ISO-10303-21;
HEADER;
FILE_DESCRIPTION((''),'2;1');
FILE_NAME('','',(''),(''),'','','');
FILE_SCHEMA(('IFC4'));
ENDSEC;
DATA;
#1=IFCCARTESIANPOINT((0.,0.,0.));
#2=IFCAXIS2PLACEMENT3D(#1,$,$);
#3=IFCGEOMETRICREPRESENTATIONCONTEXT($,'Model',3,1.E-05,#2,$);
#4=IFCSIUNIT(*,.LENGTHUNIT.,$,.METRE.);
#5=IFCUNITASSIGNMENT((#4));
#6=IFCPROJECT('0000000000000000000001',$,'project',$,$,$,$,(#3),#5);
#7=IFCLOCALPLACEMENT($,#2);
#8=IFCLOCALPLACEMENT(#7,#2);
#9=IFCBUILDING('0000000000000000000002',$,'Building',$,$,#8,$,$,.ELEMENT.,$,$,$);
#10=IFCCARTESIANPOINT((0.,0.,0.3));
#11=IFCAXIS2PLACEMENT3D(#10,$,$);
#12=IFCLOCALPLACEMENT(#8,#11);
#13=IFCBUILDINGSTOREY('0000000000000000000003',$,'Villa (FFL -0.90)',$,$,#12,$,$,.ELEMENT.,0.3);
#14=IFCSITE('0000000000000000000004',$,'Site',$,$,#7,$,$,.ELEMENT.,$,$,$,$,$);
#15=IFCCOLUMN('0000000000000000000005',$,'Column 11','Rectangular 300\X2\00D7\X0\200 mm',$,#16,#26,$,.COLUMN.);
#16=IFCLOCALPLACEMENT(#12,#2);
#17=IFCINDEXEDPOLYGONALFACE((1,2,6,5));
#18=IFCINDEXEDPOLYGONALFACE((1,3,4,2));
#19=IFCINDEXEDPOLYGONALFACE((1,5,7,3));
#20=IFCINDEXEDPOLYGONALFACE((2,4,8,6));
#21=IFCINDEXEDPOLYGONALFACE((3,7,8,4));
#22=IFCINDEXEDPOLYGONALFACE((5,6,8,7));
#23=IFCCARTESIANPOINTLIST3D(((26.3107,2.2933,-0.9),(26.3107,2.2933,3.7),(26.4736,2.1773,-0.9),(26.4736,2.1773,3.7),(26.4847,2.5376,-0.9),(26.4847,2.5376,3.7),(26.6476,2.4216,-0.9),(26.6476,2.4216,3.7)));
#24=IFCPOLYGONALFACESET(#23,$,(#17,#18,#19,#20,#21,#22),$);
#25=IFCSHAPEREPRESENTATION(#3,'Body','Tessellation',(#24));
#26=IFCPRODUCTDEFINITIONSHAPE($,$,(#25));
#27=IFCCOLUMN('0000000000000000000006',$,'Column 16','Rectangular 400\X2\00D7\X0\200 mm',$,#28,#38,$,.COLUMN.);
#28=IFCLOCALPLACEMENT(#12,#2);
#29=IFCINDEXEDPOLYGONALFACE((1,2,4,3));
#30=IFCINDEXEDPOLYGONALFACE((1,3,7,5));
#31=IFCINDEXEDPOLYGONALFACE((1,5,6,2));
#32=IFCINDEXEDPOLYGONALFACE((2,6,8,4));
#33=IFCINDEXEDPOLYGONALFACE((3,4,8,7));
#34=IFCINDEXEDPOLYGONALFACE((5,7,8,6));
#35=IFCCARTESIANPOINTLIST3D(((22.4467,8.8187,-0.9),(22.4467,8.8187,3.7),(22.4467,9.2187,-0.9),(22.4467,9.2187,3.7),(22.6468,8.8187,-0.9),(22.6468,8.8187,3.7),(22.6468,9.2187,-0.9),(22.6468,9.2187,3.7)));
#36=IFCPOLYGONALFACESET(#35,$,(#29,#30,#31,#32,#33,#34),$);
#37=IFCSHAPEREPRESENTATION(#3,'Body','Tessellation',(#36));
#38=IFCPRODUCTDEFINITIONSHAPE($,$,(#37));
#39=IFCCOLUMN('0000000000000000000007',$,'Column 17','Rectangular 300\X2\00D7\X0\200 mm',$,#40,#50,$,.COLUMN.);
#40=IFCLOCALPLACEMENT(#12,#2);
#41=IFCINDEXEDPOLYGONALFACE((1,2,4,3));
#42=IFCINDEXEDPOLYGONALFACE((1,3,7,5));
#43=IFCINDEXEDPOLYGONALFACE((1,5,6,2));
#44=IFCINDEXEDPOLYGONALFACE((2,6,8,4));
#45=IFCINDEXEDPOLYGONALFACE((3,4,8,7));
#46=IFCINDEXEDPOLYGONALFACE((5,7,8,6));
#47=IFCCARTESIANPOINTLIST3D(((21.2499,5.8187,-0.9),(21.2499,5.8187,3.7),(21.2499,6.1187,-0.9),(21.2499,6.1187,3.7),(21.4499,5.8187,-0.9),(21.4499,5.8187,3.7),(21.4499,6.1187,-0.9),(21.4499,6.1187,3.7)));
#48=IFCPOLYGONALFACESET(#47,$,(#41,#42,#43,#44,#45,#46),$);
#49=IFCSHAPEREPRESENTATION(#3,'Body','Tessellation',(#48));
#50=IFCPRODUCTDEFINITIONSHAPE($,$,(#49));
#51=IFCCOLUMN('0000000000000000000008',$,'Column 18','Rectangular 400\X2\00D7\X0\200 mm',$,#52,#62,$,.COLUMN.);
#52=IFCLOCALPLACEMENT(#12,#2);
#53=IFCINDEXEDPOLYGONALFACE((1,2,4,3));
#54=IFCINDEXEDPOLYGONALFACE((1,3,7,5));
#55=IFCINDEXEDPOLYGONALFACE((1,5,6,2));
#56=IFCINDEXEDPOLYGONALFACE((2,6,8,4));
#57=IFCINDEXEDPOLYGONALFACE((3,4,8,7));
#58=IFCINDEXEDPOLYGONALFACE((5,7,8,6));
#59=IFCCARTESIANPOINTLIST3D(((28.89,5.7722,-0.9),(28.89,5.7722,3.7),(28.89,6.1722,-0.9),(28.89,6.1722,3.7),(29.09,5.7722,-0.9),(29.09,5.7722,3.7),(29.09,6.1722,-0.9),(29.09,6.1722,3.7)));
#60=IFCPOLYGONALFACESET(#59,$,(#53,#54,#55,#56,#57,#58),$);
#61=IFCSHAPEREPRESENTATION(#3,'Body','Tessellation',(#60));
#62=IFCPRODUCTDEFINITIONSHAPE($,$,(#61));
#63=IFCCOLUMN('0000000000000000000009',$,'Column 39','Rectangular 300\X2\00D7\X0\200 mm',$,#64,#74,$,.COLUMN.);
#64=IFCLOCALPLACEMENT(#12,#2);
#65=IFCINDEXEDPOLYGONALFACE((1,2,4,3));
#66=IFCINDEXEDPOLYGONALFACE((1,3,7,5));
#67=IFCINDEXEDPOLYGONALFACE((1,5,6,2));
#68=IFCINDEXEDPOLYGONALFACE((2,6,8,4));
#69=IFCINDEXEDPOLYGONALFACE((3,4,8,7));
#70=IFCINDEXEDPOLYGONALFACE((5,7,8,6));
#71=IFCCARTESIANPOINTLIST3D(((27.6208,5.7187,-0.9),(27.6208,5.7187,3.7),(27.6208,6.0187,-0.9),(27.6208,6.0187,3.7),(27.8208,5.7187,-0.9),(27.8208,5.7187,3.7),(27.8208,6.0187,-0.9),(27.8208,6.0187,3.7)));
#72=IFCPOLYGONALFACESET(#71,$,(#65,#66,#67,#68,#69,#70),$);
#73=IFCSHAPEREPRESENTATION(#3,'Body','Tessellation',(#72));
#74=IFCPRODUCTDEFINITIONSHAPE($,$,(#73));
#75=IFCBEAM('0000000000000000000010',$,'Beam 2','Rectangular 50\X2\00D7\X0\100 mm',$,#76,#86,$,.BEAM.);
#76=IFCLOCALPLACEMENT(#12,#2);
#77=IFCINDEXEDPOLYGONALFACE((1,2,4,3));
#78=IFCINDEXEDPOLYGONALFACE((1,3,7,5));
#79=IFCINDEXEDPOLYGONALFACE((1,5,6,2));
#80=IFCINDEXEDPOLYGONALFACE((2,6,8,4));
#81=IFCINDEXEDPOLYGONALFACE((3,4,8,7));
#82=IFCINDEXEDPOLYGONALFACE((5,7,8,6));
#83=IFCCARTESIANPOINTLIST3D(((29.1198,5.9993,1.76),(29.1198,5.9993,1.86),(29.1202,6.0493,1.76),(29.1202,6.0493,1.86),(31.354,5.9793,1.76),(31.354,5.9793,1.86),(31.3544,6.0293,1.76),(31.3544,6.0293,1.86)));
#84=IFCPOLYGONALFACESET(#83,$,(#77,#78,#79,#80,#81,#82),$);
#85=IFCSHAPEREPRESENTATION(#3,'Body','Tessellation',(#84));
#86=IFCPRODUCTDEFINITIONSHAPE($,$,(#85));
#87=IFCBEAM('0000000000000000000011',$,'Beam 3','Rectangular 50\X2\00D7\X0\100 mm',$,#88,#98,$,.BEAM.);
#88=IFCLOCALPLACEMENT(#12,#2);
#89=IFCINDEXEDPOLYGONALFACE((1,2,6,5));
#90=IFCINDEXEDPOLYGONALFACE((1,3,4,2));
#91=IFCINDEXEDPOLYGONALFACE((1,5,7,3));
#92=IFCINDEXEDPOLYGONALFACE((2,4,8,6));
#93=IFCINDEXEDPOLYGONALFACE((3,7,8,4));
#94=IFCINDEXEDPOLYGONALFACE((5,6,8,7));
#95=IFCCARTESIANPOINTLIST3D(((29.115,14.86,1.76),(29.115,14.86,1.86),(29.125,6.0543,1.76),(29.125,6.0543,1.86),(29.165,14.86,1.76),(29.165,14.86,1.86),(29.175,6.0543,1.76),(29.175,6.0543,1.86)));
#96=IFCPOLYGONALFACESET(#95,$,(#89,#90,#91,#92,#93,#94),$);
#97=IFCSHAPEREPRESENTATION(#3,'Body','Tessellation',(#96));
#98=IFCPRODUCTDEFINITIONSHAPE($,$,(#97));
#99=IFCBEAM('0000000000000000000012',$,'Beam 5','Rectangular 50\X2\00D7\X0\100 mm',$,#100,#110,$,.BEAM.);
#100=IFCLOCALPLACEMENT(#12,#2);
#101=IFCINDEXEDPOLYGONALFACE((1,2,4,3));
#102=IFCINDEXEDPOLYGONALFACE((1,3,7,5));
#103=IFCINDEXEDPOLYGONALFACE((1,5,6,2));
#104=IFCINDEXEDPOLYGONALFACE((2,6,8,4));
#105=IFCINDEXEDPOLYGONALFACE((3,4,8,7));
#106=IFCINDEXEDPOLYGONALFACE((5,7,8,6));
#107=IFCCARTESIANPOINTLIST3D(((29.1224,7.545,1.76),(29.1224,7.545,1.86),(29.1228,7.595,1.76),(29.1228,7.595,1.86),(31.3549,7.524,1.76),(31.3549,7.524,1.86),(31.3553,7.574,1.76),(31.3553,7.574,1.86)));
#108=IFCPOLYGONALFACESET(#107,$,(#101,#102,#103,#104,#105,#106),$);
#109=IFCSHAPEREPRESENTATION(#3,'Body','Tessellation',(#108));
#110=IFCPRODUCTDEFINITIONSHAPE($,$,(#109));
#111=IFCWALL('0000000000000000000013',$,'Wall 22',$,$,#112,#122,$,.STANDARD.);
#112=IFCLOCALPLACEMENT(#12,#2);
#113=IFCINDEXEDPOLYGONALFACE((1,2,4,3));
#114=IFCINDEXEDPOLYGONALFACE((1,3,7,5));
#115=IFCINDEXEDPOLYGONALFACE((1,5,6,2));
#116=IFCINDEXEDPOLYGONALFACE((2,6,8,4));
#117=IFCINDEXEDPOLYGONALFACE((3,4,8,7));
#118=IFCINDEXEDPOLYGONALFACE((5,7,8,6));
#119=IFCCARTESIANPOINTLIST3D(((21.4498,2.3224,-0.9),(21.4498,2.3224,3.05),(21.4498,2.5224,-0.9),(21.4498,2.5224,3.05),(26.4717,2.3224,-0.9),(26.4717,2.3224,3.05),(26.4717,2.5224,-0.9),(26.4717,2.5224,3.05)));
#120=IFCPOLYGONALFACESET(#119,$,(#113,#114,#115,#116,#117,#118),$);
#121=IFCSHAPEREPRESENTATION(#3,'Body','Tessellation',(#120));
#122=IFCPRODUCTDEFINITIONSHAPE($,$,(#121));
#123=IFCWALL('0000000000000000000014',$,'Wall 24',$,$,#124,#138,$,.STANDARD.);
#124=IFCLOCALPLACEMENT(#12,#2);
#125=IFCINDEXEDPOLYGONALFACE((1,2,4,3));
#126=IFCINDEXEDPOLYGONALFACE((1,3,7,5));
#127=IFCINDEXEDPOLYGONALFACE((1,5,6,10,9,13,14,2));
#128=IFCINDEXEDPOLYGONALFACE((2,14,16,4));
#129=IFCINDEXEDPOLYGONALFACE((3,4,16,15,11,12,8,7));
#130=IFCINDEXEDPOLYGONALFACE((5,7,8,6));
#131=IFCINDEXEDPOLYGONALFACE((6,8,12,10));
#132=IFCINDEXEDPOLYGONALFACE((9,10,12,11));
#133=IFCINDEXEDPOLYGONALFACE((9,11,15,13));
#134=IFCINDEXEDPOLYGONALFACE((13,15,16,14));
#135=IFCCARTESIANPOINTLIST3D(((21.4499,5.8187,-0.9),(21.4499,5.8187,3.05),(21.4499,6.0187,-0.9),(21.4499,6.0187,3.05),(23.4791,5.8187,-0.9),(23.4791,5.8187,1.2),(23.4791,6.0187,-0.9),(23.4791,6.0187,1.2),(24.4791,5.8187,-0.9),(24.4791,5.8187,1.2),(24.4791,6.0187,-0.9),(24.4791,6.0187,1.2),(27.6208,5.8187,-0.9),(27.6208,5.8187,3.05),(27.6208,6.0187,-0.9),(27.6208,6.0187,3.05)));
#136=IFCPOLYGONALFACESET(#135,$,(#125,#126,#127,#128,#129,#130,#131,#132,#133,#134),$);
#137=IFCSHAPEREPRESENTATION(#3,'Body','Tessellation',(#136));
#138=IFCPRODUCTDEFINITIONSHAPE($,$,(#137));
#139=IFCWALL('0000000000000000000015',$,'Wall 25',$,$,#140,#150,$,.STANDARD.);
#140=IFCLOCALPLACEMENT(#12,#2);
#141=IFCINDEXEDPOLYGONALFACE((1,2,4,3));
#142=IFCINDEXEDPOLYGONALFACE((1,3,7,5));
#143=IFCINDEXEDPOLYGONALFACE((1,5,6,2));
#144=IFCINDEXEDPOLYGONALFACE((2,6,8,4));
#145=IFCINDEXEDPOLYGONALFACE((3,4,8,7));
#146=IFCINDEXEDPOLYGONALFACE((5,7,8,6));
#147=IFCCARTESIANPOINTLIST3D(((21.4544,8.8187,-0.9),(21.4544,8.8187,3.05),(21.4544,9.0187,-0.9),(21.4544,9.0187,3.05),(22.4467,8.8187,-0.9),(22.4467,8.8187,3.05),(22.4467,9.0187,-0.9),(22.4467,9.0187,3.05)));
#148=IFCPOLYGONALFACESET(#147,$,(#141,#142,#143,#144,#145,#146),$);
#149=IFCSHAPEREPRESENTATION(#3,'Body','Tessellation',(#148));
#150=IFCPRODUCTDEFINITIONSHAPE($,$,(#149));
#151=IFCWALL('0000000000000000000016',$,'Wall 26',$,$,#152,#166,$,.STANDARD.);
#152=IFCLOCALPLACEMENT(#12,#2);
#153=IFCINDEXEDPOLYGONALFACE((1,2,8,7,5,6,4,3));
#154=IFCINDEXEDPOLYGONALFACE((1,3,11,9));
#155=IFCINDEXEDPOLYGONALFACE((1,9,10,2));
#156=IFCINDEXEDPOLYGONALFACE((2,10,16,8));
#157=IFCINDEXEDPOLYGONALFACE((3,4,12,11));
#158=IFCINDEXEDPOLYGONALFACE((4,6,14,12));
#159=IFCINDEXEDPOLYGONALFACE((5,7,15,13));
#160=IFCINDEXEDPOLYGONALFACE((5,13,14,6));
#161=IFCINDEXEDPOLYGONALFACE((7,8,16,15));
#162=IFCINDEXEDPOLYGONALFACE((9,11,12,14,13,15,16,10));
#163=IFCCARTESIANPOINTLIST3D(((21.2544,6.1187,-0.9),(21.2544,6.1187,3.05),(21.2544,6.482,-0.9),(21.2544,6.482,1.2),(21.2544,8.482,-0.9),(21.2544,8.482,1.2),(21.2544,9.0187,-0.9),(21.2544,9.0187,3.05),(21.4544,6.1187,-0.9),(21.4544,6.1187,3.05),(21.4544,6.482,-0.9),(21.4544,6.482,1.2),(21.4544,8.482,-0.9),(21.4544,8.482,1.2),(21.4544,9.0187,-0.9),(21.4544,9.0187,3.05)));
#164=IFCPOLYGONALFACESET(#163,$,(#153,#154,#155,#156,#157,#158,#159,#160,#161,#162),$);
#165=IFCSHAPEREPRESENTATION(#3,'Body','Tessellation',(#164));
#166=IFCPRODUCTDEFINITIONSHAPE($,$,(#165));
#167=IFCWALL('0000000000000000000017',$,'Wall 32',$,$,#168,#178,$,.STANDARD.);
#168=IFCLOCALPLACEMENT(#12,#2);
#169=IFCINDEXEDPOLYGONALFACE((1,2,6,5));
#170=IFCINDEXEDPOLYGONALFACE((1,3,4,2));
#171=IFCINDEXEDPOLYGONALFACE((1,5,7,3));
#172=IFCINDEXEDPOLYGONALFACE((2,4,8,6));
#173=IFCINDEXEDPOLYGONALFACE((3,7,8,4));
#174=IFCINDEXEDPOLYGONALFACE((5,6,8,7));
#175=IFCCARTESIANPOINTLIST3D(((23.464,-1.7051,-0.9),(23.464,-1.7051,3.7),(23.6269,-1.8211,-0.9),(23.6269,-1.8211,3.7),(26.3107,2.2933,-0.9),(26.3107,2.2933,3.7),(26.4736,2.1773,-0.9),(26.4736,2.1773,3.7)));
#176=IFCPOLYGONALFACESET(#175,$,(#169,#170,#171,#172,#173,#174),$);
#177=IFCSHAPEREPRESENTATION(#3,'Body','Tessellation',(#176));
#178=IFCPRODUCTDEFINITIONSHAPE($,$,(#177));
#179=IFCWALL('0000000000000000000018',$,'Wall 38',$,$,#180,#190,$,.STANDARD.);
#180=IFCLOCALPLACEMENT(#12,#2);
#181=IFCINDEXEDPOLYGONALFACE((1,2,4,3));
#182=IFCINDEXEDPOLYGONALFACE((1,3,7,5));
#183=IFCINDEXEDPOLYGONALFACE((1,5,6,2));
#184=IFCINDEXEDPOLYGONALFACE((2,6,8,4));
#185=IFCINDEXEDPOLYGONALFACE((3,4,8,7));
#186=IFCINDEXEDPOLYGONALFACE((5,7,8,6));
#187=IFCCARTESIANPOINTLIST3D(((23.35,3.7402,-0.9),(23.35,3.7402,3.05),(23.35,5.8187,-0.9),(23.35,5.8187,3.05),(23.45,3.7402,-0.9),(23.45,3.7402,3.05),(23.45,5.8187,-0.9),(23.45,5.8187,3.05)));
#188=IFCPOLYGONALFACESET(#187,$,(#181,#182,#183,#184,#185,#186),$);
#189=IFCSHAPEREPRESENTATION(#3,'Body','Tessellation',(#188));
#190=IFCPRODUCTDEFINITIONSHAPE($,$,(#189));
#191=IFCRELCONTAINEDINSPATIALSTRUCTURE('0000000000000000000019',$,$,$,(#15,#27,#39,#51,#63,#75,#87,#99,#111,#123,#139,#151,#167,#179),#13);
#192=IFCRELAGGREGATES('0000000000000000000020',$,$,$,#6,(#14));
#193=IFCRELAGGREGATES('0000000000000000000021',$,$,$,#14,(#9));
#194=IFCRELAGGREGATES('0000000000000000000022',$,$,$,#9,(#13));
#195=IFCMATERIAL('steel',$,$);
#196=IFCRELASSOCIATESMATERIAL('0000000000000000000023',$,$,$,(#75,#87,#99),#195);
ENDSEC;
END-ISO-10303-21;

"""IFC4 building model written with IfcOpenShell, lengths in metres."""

from ifc_helpers import new_model, si_unit, frame, frame_2d, origin, place, context, project, spatial, polyline, rectangle, outline, extrude, material, element, save


model = new_model("IFC4")

# Units and contexts
model_context = context("Model", 3, precision=1e-05, world=origin())
ifc_project = project(units=[si_unit("LENGTHUNIT", "METRE")], contexts=[model_context])

# Site, building, storey
site_placement = place(None, origin())
site = spatial("IfcSite", under=ifc_project, at=site_placement, Name="Site", CompositionType="ELEMENT")
building_placement = place(site_placement, origin())
building = spatial("IfcBuilding", under=site, at=building_placement, Name="Building", CompositionType="ELEMENT")
storey_placement = place(building_placement, frame((0.0, 0.0, 0.3)))
storey = spatial("IfcBuildingStorey", under=building, at=storey_placement, Name="Villa (FFL -0.90)", CompositionType="ELEMENT", Elevation=0.3)

# Columns
column_1_placement = place(storey_placement, frame((26.4792, 2.3575, -0.9), z_axis=(0.0, 0.0, 1.0), x_axis=(0.579992, 0.814622, 0.0)))
element("IfcColumn", 1, at=column_1_placement, inside=storey, Name="Column 11", Description="Rectangular 300×200 mm", PredefinedType="COLUMN", context=model_context, shape_type="SweptSolid", body=[
    extrude(outline(polyline([(-0.15, -0.1), (0.15, -0.1), (0.15, 0.1), (-0.15, 0.1), (-0.15, -0.1)])), origin(), (0.0, 0.0, 1.0), 4.6),
])
column_2_placement = place(storey_placement, frame((22.5467, 9.0187, -0.9), z_axis=(0.0, 0.0, 1.0), x_axis=(0.0, 1.0, 0.0)))
element("IfcColumn", 2, at=column_2_placement, inside=storey, Name="Column 16", Description="Rectangular 400×200 mm", PredefinedType="COLUMN", context=model_context, shape_type="SweptSolid", body=[
    extrude(outline(polyline([(-0.2, -0.1), (0.2, -0.1), (0.2, 0.1), (-0.2, 0.1), (-0.2, -0.1)])), origin(), (0.0, 0.0, 1.0), 4.6),
])
column_3_placement = place(storey_placement, frame((21.3499, 5.9687, -0.9), z_axis=(0.0, 0.0, 1.0), x_axis=(0.0, 1.0, 0.0)))
element("IfcColumn", 3, at=column_3_placement, inside=storey, Name="Column 17", Description="Rectangular 300×200 mm", PredefinedType="COLUMN", context=model_context, shape_type="SweptSolid", body=[
    extrude(outline(polyline([(-0.15, -0.1), (0.15, -0.1), (0.15, 0.1), (-0.15, 0.1), (-0.15, -0.1)])), origin(), (0.0, 0.0, 1.0), 4.6),
])
column_4_placement = place(storey_placement, frame((28.99, 5.9722, -0.9), z_axis=(0.0, 0.0, 1.0), x_axis=(0.0, 1.0, 0.0)))
element("IfcColumn", 4, at=column_4_placement, inside=storey, Name="Column 18", Description="Rectangular 400×200 mm", PredefinedType="COLUMN", context=model_context, shape_type="SweptSolid", body=[
    extrude(outline(polyline([(-0.2, -0.1), (0.2, -0.1), (0.2, 0.1), (-0.2, 0.1), (-0.2, -0.1)])), origin(), (0.0, 0.0, 1.0), 4.6),
])
column_5_placement = place(storey_placement, frame((27.7208, 5.8687, -0.9), z_axis=(0.0, 0.0, 1.0), x_axis=(0.0, 1.0, 0.0)))
element("IfcColumn", 5, at=column_5_placement, inside=storey, Name="Column 39", Description="Rectangular 300×200 mm", PredefinedType="COLUMN", context=model_context, shape_type="SweptSolid", body=[
    extrude(outline(polyline([(-0.15, -0.1), (0.15, -0.1), (0.15, 0.1), (-0.15, 0.1), (-0.15, -0.1)])), origin(), (0.0, 0.0, 1.0), 4.6),
])

# Beams
ifc_material = material(Name="steel")
beam_1_placement = place(storey_placement, frame((29.12, 6.0243, 1.81), z_axis=(0.99996, -0.008951, 0.0), x_axis=(0.008951, 0.99996, 0.0)))
element("IfcBeam", 6, at=beam_1_placement, inside=storey, material=ifc_material, Name="Beam 2", Description="Rectangular 50×100 mm", PredefinedType="BEAM", context=model_context, shape_type="SweptSolid", body=[
    extrude(outline(polyline([(-0.025, -0.05), (0.025, -0.05), (0.025, 0.05), (-0.025, 0.05), (-0.025, -0.05)])), origin(), (0.0, 0.0, 1.0), 2.2343),
])
beam_2_placement = place(storey_placement, frame((29.15, 6.0543, 1.81), z_axis=(-0.001136, 0.999999, 0.0), x_axis=(-0.999999, -0.001136, 0.0)))
element("IfcBeam", 7, at=beam_2_placement, inside=storey, material=ifc_material, Name="Beam 3", Description="Rectangular 50×100 mm", PredefinedType="BEAM", context=model_context, shape_type="SweptSolid", body=[
    extrude(outline(polyline([(-0.025, -0.05), (0.025, -0.05), (0.025, 0.05), (-0.025, 0.05), (-0.025, -0.05)])), origin(), (0.0, 0.0, 1.0), 8.8057),
])
beam_3_placement = place(storey_placement, frame((29.1226, 7.57, 1.81), z_axis=(0.999956, -0.009406, 0.0), x_axis=(0.009406, 0.999956, 0.0)))
element("IfcBeam", 8, at=beam_3_placement, inside=storey, material=ifc_material, Name="Beam 5", Description="Rectangular 50×100 mm", PredefinedType="BEAM", context=model_context, shape_type="SweptSolid", body=[
    extrude(outline(polyline([(-0.025, -0.05), (0.025, -0.05), (0.025, 0.05), (-0.025, 0.05), (-0.025, -0.05)])), origin(), (0.0, 0.0, 1.0), 2.2326),
])

# Wall
wall_1_placement = place(storey_placement, frame((21.4498, 2.4224, -0.9), z_axis=(0.0, 0.0, 1.0), x_axis=(1.0, 0.0, 0.0)))
element("IfcWall", 9, at=wall_1_placement, inside=storey, Name="Wall 22", PredefinedType="STANDARD", context=model_context, shape_type="SweptSolid", body=[
    extrude(rectangle(XDim=5.022, YDim=0.2, at=frame_2d((2.511, 0.0))), origin(), (0.0, 0.0, 1.0), 3.95),
])

# Wall, opening
wall_2_placement = place(storey_placement, frame((21.4499, 5.9187, -0.9), z_axis=(0.0, 0.0, 1.0), x_axis=(1.0, 0.0, 0.0)))
wall_2 = element("IfcWall", 10, at=wall_2_placement, inside=storey, Name="Wall 24", PredefinedType="STANDARD", context=model_context, shape_type="SweptSolid", body=[
    extrude(rectangle(XDim=6.1709, YDim=0.2, at=frame_2d((3.0855, 0.0))), origin(), (0.0, 0.0, 1.0), 3.95),
])
opening_1_placement = place(storey_placement, frame((23.4791, 5.9187, -0.9), z_axis=(0.0, 0.0, 1.0), x_axis=(1.0, 0.0, 0.0)))
element("IfcOpeningElement", 11, at=opening_1_placement, cuts=wall_2, PredefinedType="OPENING", context=model_context, shape_type="SweptSolid", body=[
    extrude(rectangle(XDim=1.0, YDim=0.26, at=frame_2d((0.5, 0.0))), origin(), (0.0, 0.0, 1.0), 2.1),
])

# Wall
wall_3_placement = place(storey_placement, frame((21.4544, 8.9187, -0.9), z_axis=(0.0, 0.0, 1.0), x_axis=(1.0, 0.0, 0.0)))
element("IfcWall", 12, at=wall_3_placement, inside=storey, Name="Wall 25", PredefinedType="STANDARD", context=model_context, shape_type="SweptSolid", body=[
    extrude(rectangle(XDim=0.9923, YDim=0.2, at=frame_2d((0.4962, 0.0))), origin(), (0.0, 0.0, 1.0), 3.95),
])

# Wall, opening
wall_4_placement = place(storey_placement, frame((21.3544, 9.0187, -0.9), z_axis=(0.0, 0.0, 1.0), x_axis=(0.0, -1.0, 0.0)))
wall_4 = element("IfcWall", 13, at=wall_4_placement, inside=storey, Name="Wall 26", PredefinedType="STANDARD", context=model_context, shape_type="SweptSolid", body=[
    extrude(rectangle(XDim=2.9, YDim=0.2, at=frame_2d((1.45, 0.0))), origin(), (0.0, 0.0, 1.0), 3.95),
])
opening_2_placement = place(storey_placement, frame((21.3544, 8.482, -0.9), z_axis=(0.0, 0.0, 1.0), x_axis=(0.0, -1.0, 0.0)))
element("IfcOpeningElement", 14, at=opening_2_placement, cuts=wall_4, PredefinedType="OPENING", context=model_context, shape_type="SweptSolid", body=[
    extrude(rectangle(XDim=2.0, YDim=0.26, at=frame_2d((1.0, 0.0))), origin(), (0.0, 0.0, 1.0), 2.1),
])

# Walls
wall_5_placement = place(storey_placement, frame((26.3922, 2.2353, -0.9), z_axis=(0.0, 0.0, 1.0), x_axis=(-0.579992, -0.814622, 0.0)))
element("IfcWall", 15, at=wall_5_placement, inside=storey, Name="Wall 32", PredefinedType="STANDARD", context=model_context, shape_type="SweptSolid", body=[
    extrude(rectangle(XDim=4.9083, YDim=0.2, at=frame_2d((2.4541, 0.0))), origin(), (0.0, 0.0, 1.0), 4.6),
])
wall_6_placement = place(storey_placement, frame((23.4, 5.8187, -0.9), z_axis=(0.0, 0.0, 1.0), x_axis=(0.0, -1.0, 0.0)))
element("IfcWall", 16, at=wall_6_placement, inside=storey, Name="Wall 38", PredefinedType="STANDARD", context=model_context, shape_type="SweptSolid", body=[
    extrude(rectangle(XDim=2.0785, YDim=0.1, at=frame_2d((1.0393, 0.0))), origin(), (0.0, 0.0, 1.0), 3.95),
])

save(model, "model.ifc")
